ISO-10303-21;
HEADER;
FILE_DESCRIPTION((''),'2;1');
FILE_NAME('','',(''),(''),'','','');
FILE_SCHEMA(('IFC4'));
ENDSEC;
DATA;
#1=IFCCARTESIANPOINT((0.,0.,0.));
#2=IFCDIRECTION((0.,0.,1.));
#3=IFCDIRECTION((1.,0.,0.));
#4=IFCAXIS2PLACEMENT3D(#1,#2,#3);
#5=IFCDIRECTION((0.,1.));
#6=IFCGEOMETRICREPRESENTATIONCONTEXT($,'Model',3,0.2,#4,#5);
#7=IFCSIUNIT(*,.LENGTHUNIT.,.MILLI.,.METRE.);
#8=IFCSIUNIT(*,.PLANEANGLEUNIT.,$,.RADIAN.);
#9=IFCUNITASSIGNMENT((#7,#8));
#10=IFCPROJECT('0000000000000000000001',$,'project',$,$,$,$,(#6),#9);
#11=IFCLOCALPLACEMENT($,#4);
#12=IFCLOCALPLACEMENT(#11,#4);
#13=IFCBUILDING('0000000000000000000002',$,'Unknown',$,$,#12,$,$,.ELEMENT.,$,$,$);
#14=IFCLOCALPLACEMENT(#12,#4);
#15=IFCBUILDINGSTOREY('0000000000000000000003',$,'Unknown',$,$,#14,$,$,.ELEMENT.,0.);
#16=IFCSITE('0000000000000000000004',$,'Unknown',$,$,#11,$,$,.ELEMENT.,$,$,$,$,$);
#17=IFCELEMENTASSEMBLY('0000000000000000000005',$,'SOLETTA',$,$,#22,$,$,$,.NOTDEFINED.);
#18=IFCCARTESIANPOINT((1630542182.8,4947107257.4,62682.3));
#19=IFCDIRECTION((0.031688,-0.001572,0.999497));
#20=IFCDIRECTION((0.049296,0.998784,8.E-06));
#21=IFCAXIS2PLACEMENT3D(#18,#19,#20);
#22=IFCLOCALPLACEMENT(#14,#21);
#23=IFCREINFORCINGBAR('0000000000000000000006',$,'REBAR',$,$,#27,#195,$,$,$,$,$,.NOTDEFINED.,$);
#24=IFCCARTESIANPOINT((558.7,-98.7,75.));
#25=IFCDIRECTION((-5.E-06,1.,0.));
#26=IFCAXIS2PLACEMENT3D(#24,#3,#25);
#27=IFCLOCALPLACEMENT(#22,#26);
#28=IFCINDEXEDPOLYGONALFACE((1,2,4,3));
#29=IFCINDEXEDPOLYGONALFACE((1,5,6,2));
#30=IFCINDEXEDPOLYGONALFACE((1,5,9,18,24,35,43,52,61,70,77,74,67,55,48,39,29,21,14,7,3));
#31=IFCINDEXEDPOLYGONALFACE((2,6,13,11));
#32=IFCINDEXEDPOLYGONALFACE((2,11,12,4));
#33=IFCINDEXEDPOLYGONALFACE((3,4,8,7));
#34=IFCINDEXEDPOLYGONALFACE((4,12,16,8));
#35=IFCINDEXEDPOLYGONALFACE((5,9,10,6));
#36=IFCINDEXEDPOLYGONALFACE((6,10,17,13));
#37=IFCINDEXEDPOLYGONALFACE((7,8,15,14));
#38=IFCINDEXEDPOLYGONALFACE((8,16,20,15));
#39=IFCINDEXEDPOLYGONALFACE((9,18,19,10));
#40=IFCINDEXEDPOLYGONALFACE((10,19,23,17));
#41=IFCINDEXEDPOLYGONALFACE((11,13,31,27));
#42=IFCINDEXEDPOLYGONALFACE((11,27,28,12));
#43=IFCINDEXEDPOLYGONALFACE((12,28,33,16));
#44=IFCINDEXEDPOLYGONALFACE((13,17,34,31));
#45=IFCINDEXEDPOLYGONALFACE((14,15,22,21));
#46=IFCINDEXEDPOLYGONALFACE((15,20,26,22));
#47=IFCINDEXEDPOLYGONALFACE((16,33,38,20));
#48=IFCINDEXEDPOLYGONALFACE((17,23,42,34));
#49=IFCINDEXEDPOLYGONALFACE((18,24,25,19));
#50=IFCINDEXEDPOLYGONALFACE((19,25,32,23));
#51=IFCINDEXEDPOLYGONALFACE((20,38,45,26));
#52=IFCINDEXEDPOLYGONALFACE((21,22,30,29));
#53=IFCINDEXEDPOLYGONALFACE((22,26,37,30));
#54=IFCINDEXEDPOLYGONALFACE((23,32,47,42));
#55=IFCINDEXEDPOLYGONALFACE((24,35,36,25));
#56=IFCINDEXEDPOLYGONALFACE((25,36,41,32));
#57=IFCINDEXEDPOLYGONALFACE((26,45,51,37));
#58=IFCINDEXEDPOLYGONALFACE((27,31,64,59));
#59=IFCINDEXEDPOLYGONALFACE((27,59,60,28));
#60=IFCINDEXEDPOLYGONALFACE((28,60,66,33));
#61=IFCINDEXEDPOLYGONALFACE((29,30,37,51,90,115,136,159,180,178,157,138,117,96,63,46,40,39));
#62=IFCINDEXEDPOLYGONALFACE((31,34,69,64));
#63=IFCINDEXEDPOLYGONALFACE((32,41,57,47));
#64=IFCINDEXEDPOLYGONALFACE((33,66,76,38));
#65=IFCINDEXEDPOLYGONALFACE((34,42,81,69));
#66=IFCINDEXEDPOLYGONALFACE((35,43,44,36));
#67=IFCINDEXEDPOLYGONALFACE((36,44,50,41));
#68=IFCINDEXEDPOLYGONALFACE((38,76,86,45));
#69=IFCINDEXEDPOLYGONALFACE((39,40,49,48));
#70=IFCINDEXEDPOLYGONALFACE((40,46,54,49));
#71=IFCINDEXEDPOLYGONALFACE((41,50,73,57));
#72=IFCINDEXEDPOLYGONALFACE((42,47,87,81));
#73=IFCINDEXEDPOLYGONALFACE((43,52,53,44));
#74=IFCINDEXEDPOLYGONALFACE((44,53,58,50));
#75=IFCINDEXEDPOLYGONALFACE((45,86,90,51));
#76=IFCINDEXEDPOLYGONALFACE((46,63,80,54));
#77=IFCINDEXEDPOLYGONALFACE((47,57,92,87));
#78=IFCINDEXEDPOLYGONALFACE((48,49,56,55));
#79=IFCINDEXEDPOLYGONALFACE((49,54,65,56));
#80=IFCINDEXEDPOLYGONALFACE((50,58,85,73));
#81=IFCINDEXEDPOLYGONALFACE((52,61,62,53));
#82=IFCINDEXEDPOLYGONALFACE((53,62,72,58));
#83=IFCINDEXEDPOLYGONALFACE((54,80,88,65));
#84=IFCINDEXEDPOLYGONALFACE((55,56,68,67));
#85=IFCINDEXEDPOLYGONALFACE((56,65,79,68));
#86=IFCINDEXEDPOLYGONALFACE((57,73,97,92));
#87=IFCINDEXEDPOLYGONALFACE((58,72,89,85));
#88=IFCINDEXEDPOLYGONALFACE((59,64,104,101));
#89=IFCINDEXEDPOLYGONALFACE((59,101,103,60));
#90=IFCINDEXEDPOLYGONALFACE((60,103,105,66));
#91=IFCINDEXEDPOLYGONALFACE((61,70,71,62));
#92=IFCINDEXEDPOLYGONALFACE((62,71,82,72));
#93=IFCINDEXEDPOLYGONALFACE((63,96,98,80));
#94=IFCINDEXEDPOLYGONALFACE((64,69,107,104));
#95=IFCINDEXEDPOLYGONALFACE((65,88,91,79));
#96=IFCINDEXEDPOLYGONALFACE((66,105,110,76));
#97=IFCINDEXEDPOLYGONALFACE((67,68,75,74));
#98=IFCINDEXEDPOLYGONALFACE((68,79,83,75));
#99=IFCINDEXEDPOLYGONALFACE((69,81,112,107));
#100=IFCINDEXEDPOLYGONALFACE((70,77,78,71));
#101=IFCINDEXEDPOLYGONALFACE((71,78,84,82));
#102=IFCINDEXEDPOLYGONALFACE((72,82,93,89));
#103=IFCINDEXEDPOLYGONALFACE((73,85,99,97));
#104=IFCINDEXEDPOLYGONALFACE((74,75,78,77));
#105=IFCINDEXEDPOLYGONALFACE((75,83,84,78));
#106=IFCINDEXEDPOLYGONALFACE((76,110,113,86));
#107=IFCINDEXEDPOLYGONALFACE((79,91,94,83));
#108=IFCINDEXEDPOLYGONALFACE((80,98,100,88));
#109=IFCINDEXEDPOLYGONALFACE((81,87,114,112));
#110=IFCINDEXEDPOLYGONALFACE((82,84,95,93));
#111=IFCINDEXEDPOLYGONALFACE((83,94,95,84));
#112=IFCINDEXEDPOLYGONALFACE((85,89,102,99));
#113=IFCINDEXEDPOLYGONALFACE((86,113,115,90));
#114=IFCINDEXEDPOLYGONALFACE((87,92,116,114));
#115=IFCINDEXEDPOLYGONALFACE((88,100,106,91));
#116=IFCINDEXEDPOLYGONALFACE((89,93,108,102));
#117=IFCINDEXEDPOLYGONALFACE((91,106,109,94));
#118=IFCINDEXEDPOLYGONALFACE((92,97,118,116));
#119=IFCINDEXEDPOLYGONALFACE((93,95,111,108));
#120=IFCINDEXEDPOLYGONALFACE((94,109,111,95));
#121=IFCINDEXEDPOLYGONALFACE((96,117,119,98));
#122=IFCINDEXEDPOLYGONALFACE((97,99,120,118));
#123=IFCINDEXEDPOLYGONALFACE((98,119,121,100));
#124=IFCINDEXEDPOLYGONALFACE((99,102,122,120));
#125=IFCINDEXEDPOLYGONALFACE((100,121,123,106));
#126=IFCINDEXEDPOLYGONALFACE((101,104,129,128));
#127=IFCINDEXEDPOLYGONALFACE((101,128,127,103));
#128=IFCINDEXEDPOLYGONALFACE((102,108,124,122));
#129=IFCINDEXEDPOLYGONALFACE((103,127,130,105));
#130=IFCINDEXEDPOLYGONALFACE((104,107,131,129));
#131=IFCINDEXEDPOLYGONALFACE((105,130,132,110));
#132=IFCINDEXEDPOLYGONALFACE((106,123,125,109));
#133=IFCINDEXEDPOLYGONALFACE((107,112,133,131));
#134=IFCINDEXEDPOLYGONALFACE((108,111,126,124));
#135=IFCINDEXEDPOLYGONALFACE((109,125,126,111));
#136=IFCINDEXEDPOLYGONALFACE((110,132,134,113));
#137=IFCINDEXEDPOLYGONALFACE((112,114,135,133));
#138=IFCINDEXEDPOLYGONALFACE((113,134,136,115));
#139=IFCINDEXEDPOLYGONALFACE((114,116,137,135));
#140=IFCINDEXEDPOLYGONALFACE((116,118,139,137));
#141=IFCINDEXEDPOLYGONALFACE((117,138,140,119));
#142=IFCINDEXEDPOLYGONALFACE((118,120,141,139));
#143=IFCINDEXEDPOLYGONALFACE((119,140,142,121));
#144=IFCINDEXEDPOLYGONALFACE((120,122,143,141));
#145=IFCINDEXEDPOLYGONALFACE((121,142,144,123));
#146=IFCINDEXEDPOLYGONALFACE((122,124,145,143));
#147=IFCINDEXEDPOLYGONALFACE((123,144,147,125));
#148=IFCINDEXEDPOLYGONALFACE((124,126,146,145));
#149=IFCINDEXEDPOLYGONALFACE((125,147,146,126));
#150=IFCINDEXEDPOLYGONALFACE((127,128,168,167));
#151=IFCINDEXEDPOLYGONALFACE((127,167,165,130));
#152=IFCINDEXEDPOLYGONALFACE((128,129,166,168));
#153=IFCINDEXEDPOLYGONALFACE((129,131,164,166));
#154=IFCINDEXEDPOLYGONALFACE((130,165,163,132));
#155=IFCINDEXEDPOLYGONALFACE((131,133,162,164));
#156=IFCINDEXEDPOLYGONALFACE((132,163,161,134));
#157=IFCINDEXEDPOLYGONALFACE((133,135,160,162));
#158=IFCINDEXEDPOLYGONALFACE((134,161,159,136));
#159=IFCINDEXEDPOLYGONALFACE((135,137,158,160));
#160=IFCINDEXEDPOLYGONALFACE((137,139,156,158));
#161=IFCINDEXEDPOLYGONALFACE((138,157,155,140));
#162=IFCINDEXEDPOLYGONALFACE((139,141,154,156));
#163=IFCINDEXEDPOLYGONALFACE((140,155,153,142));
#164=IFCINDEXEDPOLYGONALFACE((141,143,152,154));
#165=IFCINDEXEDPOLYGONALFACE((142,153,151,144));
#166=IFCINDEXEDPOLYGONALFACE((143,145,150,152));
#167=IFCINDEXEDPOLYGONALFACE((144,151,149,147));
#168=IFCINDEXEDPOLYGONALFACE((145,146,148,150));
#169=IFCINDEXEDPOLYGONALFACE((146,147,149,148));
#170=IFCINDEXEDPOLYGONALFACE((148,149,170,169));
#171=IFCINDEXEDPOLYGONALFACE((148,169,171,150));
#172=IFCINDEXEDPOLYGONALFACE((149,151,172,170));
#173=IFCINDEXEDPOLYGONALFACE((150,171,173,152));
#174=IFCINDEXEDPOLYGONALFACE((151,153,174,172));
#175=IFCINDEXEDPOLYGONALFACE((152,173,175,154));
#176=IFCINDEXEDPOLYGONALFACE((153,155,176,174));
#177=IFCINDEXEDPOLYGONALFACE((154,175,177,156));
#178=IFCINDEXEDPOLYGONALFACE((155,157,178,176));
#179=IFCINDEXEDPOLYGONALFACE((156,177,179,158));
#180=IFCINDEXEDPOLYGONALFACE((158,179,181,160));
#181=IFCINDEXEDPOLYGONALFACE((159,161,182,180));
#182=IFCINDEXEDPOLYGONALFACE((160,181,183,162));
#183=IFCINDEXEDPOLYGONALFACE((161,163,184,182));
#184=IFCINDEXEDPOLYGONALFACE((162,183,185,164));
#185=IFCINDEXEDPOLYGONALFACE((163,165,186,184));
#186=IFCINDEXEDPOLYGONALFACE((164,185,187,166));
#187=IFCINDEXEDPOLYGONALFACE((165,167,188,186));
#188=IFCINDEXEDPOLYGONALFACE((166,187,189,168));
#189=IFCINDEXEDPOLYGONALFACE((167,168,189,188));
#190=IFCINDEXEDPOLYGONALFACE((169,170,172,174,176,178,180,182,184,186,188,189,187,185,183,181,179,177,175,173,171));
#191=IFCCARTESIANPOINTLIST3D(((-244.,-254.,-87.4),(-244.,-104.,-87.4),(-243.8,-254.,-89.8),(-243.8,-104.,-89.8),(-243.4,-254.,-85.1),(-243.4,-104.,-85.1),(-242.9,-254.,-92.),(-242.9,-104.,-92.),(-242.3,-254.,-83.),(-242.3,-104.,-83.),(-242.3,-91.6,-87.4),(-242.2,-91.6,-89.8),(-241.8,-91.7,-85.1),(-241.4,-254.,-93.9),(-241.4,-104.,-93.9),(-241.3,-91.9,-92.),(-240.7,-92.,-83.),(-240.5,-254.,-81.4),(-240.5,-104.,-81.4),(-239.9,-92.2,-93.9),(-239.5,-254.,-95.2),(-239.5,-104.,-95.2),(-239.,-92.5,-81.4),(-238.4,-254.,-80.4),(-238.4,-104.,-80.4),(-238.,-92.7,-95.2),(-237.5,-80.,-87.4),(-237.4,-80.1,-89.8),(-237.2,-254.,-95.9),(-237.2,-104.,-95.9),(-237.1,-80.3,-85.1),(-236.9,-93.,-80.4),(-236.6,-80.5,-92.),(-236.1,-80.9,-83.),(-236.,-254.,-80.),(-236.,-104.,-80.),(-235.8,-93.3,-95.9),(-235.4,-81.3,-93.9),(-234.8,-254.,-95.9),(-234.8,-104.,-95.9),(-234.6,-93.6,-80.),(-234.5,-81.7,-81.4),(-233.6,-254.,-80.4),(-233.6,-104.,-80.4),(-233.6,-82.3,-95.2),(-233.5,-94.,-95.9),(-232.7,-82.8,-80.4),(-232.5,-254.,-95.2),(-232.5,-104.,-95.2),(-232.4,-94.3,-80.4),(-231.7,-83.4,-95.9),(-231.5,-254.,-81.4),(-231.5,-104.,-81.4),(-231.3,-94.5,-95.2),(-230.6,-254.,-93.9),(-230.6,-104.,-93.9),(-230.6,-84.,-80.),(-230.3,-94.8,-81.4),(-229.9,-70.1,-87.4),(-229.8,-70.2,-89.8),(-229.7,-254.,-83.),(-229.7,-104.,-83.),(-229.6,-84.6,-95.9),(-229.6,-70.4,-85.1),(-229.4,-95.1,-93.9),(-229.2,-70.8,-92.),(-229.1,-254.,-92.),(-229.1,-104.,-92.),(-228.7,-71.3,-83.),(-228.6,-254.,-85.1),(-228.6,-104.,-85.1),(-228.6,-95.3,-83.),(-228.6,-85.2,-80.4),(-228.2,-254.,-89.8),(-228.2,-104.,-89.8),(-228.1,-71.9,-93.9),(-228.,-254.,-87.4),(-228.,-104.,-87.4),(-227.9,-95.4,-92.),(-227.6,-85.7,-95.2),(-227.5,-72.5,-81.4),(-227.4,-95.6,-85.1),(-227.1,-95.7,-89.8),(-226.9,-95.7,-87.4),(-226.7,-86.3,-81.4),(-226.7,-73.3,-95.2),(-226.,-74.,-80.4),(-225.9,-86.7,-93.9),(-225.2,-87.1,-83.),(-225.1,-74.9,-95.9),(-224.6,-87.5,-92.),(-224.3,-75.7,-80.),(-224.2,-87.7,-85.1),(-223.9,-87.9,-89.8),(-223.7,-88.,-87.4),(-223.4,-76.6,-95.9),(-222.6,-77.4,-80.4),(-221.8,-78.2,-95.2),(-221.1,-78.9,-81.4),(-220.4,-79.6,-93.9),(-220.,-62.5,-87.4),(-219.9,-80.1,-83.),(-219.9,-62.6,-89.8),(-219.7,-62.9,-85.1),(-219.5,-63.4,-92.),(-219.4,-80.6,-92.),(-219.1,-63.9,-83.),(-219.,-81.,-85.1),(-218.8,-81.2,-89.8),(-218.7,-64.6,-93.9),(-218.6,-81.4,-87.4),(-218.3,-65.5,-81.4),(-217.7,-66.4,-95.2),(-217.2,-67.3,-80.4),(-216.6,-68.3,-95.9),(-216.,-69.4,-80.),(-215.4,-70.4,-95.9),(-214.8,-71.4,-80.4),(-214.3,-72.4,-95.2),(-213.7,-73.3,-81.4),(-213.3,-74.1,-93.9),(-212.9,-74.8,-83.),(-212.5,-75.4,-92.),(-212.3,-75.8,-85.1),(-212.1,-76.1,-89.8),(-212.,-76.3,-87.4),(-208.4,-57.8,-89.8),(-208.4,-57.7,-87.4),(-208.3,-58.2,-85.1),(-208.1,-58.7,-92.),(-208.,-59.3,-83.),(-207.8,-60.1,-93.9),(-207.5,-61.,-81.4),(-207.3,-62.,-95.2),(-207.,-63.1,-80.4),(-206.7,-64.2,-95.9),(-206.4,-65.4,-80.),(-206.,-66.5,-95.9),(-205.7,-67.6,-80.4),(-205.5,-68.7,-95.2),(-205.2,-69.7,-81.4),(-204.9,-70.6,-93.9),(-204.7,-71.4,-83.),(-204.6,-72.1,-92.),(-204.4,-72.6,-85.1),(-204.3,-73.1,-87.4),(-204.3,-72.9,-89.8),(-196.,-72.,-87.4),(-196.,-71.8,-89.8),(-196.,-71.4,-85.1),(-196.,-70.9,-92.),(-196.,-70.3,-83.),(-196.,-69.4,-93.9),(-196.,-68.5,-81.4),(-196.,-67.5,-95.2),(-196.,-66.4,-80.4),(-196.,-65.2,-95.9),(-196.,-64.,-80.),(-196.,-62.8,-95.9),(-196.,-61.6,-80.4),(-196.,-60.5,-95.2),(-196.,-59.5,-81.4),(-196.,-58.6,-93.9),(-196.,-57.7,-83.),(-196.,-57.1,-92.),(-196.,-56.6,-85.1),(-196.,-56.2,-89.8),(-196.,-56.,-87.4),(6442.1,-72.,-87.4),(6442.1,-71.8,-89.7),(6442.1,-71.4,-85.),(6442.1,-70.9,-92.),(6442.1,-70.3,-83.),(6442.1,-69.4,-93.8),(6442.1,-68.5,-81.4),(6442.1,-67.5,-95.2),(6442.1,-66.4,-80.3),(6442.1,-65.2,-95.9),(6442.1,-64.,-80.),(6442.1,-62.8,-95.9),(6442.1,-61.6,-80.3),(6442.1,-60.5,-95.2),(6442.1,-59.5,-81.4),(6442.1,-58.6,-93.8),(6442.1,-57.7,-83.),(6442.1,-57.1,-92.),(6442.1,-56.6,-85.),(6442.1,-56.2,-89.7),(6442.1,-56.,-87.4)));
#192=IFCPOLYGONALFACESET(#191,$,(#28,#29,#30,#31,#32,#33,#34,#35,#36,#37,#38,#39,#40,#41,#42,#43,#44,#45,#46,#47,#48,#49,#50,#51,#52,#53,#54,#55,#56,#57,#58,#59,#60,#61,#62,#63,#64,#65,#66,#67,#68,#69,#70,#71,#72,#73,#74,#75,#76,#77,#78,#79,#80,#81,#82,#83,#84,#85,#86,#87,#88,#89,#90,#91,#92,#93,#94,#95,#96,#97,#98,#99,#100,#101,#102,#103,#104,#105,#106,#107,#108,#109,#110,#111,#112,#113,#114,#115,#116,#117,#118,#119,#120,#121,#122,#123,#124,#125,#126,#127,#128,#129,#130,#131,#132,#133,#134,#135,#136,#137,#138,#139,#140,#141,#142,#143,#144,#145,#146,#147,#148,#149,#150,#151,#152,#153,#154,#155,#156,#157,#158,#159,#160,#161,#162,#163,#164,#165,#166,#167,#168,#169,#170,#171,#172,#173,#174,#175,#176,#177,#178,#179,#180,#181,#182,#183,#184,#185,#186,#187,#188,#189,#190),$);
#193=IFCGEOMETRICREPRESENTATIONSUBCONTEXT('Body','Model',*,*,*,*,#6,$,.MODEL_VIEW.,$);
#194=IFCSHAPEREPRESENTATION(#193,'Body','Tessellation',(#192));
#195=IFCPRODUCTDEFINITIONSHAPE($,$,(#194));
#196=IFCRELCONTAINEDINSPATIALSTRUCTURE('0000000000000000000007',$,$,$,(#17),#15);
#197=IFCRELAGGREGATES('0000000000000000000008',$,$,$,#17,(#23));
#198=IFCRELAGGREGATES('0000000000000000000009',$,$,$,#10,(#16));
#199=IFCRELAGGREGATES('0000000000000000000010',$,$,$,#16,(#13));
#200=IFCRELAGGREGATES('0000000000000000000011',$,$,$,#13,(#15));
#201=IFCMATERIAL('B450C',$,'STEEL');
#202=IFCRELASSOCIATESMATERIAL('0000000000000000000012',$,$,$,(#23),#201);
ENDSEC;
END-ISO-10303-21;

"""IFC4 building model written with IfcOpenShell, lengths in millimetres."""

from ifc_helpers import new_model, entity, si_unit, direction, frame, origin_with_axes, place, context, subcontext, project, spatial, material, element, aggregate, save


model = new_model("IFC4")

# Units and contexts
model_context = context("Model", 3, precision=0.2, world=origin_with_axes(), true_north=direction((0.0, 1.0)))
body_context = subcontext(model_context, "Body", "Model", "MODEL_VIEW")
ifc_project = project(units=[si_unit("LENGTHUNIT", "METRE", prefix="MILLI"), si_unit("PLANEANGLEUNIT", "RADIAN")], contexts=[model_context])

# Site, building, storey
site_placement = place(None, origin_with_axes())
site = spatial("IfcSite", under=ifc_project, at=site_placement, Name="Unknown", CompositionType="ELEMENT")
building_placement = place(site_placement, origin_with_axes())
building = spatial("IfcBuilding", under=site, at=building_placement, Name="Unknown", CompositionType="ELEMENT")
storey_placement = place(building_placement, origin_with_axes())
storey = spatial("IfcBuildingStorey", under=building, at=storey_placement, Name="Unknown", CompositionType="ELEMENT", Elevation=0.0)

# Element assembly, reinforcing bar
ifc_material = material(Name="B450C", Category="STEEL")
assembly_1_placement = place(storey_placement, frame((1630542182.8, 4947107257.4, 62682.3), z_axis=(0.031688, -0.001572, 0.999497), x_axis=(0.049296, 0.998784, 0.000008)))
assembly_1 = element("IfcElementAssembly", 1, at=assembly_1_placement, inside=storey, Name="SOLETTA", PredefinedType="NOTDEFINED")
reinforcing_bar_1_placement = place(assembly_1_placement, frame((558.7, -98.7, 75.0), z_axis=(1.0, 0.0, 0.0), x_axis=(-0.000005, 1.0, 0.0)))
reinforcing_bar_1 = element("IfcReinforcingBar", 2, at=reinforcing_bar_1_placement, material=ifc_material, Name="REBAR", PredefinedType="NOTDEFINED", context=body_context, shape_type="AdvancedSweptSolid", body=[
    entity("IfcSweptDiskSolid", entity("IfcIndexedPolyCurve", entity("IfcCartesianPointList3D", [[-236.0, -254.0, -88.0], [-236.0, -104.0, -88.0], [-224.3, -75.7, -88.0], [-196.0, -64.0, -88.0], [6442.1, -64.0, -88.0]]), [entity("IfcLineIndex", [1, 2]), entity("IfcArcIndex", [2, 3, 4]), entity("IfcLineIndex", [4, 5])]), 8.0),
])
aggregate(assembly_1, [reinforcing_bar_1])

save(model, "model.ifc")
